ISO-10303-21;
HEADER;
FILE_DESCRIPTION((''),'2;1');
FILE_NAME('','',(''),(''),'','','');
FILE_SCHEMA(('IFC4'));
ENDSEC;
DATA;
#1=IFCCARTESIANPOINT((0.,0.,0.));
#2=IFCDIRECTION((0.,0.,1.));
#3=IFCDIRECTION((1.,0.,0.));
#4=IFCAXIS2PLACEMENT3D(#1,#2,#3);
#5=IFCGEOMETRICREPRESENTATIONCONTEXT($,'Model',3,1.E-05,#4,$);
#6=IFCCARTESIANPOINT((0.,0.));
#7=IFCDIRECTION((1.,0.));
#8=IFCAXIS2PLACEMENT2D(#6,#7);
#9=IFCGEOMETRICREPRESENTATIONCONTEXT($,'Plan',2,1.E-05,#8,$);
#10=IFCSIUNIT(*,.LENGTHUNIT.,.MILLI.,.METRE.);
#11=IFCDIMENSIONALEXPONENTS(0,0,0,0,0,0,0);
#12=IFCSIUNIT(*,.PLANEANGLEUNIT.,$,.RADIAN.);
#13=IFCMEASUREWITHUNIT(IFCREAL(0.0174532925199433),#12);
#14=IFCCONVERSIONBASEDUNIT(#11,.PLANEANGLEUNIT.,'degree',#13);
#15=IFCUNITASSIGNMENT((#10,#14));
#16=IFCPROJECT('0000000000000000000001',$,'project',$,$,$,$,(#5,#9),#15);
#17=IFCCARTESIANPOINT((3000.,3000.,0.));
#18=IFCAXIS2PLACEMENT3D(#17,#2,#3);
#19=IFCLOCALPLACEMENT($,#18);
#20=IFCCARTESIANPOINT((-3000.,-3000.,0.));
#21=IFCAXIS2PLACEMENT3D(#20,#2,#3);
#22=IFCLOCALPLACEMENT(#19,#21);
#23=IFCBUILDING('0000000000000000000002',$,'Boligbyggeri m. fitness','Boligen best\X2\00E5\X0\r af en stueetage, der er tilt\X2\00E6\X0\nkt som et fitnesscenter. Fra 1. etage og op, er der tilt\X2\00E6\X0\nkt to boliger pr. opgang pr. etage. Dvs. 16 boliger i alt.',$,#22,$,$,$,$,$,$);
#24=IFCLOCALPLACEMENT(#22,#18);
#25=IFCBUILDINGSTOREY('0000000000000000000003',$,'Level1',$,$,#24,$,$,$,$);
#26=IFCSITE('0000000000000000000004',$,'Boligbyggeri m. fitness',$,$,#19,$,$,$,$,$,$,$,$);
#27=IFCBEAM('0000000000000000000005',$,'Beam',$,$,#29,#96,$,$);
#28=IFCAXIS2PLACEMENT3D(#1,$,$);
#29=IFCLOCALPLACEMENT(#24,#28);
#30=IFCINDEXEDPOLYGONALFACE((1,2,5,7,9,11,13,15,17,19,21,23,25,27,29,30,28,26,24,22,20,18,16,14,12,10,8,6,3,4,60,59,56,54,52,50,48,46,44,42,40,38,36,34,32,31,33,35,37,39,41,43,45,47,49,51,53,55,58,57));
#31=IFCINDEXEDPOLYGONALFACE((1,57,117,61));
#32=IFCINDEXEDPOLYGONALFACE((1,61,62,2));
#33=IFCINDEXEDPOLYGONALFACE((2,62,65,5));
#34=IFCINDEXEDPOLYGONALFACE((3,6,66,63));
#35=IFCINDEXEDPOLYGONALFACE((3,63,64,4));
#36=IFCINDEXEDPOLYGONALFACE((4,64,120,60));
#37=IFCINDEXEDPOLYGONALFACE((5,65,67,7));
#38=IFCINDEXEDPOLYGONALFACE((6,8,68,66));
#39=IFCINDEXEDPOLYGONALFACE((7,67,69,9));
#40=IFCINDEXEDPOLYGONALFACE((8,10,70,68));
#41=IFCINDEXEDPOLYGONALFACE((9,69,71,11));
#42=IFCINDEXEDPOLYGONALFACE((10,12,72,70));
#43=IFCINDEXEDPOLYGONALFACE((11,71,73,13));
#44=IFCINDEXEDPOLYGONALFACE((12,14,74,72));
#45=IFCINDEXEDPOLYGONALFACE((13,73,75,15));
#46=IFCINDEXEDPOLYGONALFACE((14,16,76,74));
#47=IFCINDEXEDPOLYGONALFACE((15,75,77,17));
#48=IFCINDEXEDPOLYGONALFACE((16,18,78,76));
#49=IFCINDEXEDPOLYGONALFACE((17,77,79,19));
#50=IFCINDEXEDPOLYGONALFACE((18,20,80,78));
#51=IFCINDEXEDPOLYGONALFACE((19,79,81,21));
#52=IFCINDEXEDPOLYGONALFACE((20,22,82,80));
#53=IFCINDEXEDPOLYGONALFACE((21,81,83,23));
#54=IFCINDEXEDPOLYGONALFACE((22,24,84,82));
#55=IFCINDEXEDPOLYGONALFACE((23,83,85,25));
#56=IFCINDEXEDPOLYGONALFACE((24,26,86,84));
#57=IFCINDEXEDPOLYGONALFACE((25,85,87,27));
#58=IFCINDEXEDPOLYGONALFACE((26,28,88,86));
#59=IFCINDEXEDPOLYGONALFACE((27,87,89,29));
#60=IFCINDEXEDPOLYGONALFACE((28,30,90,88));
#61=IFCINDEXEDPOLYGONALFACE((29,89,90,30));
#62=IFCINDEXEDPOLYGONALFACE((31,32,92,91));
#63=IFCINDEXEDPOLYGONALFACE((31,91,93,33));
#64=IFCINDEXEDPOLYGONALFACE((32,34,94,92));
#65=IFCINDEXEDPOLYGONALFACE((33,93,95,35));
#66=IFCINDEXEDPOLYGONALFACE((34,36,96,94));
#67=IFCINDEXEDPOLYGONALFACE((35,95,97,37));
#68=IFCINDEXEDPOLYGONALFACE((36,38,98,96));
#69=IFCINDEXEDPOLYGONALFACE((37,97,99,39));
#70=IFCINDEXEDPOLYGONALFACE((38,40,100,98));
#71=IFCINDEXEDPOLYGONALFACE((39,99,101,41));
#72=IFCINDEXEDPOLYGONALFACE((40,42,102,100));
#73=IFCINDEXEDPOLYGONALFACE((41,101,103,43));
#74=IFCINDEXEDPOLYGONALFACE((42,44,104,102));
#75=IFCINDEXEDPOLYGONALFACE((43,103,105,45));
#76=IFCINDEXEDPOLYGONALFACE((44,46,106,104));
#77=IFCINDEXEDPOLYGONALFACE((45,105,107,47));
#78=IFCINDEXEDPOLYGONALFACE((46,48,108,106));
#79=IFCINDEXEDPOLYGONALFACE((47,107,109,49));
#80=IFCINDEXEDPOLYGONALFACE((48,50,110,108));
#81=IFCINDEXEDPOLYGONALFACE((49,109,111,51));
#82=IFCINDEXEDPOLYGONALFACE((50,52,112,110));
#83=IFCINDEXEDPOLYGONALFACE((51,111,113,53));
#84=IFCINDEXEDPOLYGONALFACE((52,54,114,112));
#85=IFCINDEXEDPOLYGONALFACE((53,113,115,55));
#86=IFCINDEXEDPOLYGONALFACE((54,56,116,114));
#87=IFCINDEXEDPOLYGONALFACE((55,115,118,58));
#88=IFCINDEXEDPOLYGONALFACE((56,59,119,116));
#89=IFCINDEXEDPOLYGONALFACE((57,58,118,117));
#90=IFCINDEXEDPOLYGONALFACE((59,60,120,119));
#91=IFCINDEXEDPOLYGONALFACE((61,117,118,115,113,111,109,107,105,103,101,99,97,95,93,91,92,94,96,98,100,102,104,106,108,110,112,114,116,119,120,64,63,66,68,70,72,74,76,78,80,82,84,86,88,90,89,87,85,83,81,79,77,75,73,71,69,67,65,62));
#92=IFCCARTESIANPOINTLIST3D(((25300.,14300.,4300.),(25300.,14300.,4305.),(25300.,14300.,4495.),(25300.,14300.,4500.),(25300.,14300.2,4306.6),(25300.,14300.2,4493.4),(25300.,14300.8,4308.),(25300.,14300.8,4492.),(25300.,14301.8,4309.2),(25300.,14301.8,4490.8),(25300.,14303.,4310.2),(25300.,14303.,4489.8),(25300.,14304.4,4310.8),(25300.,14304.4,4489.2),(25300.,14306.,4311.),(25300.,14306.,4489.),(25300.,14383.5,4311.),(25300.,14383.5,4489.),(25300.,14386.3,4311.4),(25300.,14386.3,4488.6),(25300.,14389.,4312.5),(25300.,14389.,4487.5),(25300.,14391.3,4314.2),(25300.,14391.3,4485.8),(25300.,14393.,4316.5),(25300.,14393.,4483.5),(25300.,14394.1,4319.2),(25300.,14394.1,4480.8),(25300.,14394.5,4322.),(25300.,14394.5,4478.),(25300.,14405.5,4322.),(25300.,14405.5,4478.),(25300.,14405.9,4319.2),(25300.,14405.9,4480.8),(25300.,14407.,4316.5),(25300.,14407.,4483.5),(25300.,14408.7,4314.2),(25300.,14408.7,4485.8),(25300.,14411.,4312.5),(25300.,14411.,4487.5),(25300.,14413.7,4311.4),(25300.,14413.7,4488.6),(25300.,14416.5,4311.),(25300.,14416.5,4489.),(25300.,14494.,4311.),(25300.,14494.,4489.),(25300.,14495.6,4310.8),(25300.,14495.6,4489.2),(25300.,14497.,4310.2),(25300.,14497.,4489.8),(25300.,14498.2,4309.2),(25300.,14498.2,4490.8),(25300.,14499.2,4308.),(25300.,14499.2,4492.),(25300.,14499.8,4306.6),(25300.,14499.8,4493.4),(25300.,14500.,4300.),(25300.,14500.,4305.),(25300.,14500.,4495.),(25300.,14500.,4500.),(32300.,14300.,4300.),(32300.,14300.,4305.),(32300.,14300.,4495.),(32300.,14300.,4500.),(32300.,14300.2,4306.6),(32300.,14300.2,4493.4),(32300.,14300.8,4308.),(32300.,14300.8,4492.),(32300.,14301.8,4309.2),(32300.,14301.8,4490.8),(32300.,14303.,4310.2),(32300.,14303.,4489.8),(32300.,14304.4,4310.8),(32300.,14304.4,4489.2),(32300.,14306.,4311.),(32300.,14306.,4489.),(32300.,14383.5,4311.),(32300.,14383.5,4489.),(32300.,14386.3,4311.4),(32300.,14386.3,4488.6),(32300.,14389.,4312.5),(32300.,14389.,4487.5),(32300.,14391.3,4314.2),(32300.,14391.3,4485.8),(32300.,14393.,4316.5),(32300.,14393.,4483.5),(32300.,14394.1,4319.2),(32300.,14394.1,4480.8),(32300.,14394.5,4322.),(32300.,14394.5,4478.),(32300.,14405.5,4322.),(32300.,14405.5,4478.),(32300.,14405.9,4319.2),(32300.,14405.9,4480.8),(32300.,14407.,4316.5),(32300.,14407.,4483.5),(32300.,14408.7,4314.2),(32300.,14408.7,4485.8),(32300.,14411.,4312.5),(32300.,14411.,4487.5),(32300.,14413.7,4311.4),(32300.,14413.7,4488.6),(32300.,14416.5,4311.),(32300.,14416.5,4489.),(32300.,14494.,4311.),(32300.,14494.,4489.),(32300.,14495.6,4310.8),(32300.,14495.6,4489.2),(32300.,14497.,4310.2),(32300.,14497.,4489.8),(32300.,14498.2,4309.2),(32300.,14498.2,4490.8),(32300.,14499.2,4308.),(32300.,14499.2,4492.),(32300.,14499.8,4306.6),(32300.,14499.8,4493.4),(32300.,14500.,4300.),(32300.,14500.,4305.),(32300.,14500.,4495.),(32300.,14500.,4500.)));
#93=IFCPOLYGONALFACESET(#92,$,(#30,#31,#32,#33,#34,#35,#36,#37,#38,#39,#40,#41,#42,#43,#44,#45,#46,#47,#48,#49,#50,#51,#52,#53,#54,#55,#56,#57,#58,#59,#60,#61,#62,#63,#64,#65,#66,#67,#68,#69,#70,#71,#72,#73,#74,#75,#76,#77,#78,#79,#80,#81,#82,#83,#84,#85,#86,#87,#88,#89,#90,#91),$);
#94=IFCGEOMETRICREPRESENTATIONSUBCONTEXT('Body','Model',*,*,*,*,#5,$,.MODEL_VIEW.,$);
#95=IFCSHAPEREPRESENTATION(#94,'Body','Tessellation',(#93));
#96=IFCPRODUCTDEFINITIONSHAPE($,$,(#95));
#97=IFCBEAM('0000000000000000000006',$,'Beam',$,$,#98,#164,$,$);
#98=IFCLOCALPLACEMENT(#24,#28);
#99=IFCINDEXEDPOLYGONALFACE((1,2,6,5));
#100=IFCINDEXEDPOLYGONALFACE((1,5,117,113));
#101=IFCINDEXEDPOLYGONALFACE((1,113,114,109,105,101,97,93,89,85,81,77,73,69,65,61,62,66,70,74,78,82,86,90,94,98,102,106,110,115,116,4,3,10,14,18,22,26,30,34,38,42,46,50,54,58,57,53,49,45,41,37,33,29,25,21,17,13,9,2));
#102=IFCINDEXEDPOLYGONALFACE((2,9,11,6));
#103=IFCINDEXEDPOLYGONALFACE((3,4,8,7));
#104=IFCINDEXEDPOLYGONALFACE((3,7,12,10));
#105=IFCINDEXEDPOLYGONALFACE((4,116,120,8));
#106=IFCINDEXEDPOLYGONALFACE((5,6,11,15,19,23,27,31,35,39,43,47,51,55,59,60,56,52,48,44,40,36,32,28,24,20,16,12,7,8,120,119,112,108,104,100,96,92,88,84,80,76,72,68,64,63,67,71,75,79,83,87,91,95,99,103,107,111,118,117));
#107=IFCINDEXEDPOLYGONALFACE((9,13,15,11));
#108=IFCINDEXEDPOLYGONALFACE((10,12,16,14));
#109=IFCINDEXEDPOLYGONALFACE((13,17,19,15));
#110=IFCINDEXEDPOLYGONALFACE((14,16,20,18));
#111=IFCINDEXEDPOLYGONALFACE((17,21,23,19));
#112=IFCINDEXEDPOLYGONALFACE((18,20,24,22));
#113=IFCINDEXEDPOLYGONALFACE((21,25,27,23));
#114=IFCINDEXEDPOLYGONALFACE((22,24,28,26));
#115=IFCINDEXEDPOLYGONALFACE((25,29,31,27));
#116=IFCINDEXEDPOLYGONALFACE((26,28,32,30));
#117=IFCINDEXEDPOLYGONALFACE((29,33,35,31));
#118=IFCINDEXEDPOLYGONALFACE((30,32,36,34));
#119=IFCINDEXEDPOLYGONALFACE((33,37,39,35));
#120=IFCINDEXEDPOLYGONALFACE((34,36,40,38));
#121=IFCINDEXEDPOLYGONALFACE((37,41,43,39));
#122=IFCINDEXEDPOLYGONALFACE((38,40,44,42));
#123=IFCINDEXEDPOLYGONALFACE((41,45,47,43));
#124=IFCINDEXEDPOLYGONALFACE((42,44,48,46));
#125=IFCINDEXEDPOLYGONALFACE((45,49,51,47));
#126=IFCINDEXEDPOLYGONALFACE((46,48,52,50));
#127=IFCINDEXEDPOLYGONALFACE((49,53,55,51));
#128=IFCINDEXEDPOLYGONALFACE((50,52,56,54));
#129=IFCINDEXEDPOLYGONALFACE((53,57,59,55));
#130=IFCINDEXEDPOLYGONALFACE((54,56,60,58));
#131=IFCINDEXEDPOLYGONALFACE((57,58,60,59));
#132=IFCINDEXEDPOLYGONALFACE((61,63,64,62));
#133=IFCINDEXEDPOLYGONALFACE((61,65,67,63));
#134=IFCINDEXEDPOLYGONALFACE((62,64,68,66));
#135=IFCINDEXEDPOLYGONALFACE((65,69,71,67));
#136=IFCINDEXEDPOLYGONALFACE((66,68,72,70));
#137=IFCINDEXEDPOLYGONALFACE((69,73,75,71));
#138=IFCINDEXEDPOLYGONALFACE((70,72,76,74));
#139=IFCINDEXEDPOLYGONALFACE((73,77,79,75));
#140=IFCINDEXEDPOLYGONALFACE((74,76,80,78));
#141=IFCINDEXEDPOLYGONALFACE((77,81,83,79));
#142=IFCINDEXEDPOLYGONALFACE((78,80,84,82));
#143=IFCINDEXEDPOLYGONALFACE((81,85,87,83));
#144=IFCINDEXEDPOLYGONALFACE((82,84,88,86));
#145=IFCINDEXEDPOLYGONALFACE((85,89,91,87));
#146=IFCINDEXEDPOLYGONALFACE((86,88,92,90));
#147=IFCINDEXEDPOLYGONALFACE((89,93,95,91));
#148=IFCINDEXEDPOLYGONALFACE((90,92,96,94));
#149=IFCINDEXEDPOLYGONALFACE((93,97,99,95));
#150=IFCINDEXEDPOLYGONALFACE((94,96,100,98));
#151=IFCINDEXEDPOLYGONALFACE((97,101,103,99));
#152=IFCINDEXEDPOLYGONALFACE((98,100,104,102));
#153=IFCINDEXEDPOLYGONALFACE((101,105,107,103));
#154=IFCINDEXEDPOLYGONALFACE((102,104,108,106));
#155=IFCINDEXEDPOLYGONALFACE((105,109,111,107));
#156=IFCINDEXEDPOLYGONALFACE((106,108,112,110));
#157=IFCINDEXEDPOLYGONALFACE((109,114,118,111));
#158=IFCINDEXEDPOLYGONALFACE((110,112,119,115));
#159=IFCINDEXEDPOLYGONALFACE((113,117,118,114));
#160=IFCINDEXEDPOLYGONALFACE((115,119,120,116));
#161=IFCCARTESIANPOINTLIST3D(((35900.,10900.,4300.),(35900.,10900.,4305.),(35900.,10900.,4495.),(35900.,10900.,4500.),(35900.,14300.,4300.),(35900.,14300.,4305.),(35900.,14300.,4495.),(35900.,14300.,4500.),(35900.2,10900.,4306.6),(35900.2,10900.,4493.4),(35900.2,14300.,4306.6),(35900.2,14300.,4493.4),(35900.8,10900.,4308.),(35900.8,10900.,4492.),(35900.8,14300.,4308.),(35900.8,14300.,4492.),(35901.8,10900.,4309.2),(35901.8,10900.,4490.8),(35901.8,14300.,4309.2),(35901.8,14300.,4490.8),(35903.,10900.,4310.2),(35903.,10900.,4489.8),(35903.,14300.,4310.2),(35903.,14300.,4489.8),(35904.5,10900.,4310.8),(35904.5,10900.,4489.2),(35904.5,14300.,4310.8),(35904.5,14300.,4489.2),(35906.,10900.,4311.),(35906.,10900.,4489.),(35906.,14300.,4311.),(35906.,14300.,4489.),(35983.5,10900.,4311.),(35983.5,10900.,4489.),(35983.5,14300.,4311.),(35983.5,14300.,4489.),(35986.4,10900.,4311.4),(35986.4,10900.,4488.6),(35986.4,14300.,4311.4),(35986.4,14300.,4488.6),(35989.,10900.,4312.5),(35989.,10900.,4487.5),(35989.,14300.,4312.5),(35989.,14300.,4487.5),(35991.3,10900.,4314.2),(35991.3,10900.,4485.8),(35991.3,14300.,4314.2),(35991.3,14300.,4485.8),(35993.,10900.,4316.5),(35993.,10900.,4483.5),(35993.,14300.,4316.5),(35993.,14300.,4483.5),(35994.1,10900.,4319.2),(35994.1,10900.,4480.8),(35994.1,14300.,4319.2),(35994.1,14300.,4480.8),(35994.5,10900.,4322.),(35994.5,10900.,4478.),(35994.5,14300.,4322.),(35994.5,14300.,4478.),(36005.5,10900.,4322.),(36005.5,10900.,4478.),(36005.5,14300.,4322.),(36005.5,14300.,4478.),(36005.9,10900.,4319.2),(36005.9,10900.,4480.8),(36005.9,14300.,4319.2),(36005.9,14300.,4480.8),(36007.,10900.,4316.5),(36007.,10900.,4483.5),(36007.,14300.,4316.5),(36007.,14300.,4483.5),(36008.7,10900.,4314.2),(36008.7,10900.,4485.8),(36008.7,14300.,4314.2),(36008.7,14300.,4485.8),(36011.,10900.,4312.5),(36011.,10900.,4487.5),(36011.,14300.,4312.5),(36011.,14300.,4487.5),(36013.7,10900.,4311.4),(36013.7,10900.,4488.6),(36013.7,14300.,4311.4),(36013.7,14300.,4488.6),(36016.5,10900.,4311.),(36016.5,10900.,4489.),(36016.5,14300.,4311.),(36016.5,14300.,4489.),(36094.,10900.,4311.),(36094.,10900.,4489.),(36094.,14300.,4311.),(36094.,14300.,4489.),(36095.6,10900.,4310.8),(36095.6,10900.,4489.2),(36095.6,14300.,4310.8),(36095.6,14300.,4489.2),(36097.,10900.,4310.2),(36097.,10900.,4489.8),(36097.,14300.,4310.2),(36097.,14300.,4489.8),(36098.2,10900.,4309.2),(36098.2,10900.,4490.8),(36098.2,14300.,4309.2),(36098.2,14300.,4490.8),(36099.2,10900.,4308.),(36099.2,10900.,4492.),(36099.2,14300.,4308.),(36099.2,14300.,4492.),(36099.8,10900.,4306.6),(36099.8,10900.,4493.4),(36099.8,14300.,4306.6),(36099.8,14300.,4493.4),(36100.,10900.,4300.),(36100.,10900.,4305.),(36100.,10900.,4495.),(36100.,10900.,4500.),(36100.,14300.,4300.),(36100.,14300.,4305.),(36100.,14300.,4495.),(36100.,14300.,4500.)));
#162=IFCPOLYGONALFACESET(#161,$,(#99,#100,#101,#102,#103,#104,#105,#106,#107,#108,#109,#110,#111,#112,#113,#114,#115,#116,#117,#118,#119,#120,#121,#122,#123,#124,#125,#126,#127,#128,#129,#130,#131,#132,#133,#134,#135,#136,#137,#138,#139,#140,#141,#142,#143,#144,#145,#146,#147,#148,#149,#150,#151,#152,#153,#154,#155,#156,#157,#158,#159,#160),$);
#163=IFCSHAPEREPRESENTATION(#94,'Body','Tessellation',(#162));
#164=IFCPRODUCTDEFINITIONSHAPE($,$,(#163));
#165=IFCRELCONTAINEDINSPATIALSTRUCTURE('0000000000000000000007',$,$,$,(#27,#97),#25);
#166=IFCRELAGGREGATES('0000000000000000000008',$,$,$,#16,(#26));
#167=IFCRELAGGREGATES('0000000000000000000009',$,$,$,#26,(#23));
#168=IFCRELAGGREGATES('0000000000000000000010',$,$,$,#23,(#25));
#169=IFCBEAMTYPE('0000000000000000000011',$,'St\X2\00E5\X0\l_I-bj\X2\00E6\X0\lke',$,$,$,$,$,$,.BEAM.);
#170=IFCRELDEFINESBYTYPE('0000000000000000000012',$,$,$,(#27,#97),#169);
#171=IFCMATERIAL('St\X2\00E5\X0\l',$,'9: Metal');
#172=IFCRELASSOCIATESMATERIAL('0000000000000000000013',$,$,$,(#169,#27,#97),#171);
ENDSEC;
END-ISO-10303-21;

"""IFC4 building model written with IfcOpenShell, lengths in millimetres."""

from ifc_helpers import new_model, entity, si_unit, converted_unit, frame, origin_with_axes, origin_2d_with_axis, place, context, subcontext, project, spatial, i_section, extrude, material, material_profile, profile_set, profile_usage, type_object, element, save


model = new_model("IFC4")

# Units and contexts
model_context = context("Model", 3, precision=1e-05, world=origin_with_axes())
plan_context = context("Plan", 2, precision=1e-05, world=origin_2d_with_axis())
body_context = subcontext(model_context, "Body", "Model", "MODEL_VIEW")
ifc_project = project(units=[si_unit("LENGTHUNIT", "METRE", prefix="MILLI"), converted_unit("PLANEANGLEUNIT", "degree", entity("IfcReal", 0.0174532925199433), si_unit("PLANEANGLEUNIT", "RADIAN"), dimensions=[0, 0, 0, 0, 0, 0, 0])], contexts=[model_context, plan_context])

# Site, building, storey
site_placement = place(None, frame((3000.0, 3000.0, 0.0), z_axis=(0.0, 0.0, 1.0), x_axis=(1.0, 0.0, 0.0)))
site = spatial("IfcSite", under=ifc_project, at=site_placement, Name="Boligbyggeri m. fitness")
building_placement = place(site_placement, frame((-3000.0, -3000.0, 0.0), z_axis=(0.0, 0.0, 1.0), x_axis=(1.0, 0.0, 0.0)))
building = spatial("IfcBuilding", under=site, at=building_placement, Name="Boligbyggeri m. fitness", Description="Boligen består af en stueetage, der er tiltænkt som et fitnesscenter. Fra 1. etage og op, er der tiltænkt to boliger pr. opgang pr. etage. Dvs. 16 boliger i alt.")
storey_placement = place(building_placement, frame((3000.0, 3000.0, 0.0), z_axis=(0.0, 0.0, 1.0), x_axis=(1.0, 0.0, 0.0)))
storey = spatial("IfcBuildingStorey", under=building, at=storey_placement, Name="Level1")

# Beams
ifc_material_1 = material(Name="Stål", Category="9: Metal")
ifc_material_profile_1 = material_profile(ifc_material_1, i_section(OverallWidth=200.0, OverallDepth=200.0, WebThickness=11.0, FlangeThickness=11.0, FilletRadius=11.0, FlangeEdgeRadius=6.0), Name="Stål", Category="9: Metal")
ifc_profile_set_1 = profile_set([ifc_material_profile_1], Name="NY_I-Profil")
beam_type = type_object("IfcBeamType", Name="Stål_I-bjælke", PredefinedType="BEAM", material=ifc_profile_set_1)
ifc_profile_usage_1 = profile_usage(ifc_profile_set_1, cardinal=7)
beam_1_placement = place(storey_placement, frame((25300.0, 14500.0, 4500.0), z_axis=(1.0, 0.0, 0.0), x_axis=(0.0, 1.0, 0.0)))
element("IfcBeam", 1, at=beam_1_placement, inside=storey, type_object=beam_type, material=ifc_profile_usage_1, Name="Beam", context=body_context, shape_type="SweptSolid", body=[
    extrude(i_section(OverallWidth=200.0, OverallDepth=200.0, WebThickness=11.0, FlangeThickness=11.0, FilletRadius=11.0, FlangeEdgeRadius=6.0), frame((-100.0, -100.0, 0.0), z_axis=(0.0, 0.0, 1.0), x_axis=(1.0, 0.0, 0.0)), (0.0, 0.0, 1.0), 7000.0),
])
ifc_profile_usage_2 = profile_usage(ifc_profile_set_1, cardinal=9)
beam_2_placement = place(storey_placement, frame((36100.0, 10900.0, 4500.0), z_axis=(0.0, 1.0, 0.0), x_axis=(-1.0, 0.0, 0.0)))
element("IfcBeam", 2, at=beam_2_placement, inside=storey, type_object=beam_type, material=ifc_profile_usage_2, Name="Beam", context=body_context, shape_type="SweptSolid", body=[
    extrude(i_section(OverallWidth=200.0, OverallDepth=200.0, WebThickness=11.0, FlangeThickness=11.0, FilletRadius=11.0, FlangeEdgeRadius=6.0), frame((100.0, -100.0, 0.0), z_axis=(0.0, 0.0, 1.0), x_axis=(1.0, 0.0, 0.0)), (0.0, 0.0, 1.0), 3400.0),
])

save(model, "model.ifc")
